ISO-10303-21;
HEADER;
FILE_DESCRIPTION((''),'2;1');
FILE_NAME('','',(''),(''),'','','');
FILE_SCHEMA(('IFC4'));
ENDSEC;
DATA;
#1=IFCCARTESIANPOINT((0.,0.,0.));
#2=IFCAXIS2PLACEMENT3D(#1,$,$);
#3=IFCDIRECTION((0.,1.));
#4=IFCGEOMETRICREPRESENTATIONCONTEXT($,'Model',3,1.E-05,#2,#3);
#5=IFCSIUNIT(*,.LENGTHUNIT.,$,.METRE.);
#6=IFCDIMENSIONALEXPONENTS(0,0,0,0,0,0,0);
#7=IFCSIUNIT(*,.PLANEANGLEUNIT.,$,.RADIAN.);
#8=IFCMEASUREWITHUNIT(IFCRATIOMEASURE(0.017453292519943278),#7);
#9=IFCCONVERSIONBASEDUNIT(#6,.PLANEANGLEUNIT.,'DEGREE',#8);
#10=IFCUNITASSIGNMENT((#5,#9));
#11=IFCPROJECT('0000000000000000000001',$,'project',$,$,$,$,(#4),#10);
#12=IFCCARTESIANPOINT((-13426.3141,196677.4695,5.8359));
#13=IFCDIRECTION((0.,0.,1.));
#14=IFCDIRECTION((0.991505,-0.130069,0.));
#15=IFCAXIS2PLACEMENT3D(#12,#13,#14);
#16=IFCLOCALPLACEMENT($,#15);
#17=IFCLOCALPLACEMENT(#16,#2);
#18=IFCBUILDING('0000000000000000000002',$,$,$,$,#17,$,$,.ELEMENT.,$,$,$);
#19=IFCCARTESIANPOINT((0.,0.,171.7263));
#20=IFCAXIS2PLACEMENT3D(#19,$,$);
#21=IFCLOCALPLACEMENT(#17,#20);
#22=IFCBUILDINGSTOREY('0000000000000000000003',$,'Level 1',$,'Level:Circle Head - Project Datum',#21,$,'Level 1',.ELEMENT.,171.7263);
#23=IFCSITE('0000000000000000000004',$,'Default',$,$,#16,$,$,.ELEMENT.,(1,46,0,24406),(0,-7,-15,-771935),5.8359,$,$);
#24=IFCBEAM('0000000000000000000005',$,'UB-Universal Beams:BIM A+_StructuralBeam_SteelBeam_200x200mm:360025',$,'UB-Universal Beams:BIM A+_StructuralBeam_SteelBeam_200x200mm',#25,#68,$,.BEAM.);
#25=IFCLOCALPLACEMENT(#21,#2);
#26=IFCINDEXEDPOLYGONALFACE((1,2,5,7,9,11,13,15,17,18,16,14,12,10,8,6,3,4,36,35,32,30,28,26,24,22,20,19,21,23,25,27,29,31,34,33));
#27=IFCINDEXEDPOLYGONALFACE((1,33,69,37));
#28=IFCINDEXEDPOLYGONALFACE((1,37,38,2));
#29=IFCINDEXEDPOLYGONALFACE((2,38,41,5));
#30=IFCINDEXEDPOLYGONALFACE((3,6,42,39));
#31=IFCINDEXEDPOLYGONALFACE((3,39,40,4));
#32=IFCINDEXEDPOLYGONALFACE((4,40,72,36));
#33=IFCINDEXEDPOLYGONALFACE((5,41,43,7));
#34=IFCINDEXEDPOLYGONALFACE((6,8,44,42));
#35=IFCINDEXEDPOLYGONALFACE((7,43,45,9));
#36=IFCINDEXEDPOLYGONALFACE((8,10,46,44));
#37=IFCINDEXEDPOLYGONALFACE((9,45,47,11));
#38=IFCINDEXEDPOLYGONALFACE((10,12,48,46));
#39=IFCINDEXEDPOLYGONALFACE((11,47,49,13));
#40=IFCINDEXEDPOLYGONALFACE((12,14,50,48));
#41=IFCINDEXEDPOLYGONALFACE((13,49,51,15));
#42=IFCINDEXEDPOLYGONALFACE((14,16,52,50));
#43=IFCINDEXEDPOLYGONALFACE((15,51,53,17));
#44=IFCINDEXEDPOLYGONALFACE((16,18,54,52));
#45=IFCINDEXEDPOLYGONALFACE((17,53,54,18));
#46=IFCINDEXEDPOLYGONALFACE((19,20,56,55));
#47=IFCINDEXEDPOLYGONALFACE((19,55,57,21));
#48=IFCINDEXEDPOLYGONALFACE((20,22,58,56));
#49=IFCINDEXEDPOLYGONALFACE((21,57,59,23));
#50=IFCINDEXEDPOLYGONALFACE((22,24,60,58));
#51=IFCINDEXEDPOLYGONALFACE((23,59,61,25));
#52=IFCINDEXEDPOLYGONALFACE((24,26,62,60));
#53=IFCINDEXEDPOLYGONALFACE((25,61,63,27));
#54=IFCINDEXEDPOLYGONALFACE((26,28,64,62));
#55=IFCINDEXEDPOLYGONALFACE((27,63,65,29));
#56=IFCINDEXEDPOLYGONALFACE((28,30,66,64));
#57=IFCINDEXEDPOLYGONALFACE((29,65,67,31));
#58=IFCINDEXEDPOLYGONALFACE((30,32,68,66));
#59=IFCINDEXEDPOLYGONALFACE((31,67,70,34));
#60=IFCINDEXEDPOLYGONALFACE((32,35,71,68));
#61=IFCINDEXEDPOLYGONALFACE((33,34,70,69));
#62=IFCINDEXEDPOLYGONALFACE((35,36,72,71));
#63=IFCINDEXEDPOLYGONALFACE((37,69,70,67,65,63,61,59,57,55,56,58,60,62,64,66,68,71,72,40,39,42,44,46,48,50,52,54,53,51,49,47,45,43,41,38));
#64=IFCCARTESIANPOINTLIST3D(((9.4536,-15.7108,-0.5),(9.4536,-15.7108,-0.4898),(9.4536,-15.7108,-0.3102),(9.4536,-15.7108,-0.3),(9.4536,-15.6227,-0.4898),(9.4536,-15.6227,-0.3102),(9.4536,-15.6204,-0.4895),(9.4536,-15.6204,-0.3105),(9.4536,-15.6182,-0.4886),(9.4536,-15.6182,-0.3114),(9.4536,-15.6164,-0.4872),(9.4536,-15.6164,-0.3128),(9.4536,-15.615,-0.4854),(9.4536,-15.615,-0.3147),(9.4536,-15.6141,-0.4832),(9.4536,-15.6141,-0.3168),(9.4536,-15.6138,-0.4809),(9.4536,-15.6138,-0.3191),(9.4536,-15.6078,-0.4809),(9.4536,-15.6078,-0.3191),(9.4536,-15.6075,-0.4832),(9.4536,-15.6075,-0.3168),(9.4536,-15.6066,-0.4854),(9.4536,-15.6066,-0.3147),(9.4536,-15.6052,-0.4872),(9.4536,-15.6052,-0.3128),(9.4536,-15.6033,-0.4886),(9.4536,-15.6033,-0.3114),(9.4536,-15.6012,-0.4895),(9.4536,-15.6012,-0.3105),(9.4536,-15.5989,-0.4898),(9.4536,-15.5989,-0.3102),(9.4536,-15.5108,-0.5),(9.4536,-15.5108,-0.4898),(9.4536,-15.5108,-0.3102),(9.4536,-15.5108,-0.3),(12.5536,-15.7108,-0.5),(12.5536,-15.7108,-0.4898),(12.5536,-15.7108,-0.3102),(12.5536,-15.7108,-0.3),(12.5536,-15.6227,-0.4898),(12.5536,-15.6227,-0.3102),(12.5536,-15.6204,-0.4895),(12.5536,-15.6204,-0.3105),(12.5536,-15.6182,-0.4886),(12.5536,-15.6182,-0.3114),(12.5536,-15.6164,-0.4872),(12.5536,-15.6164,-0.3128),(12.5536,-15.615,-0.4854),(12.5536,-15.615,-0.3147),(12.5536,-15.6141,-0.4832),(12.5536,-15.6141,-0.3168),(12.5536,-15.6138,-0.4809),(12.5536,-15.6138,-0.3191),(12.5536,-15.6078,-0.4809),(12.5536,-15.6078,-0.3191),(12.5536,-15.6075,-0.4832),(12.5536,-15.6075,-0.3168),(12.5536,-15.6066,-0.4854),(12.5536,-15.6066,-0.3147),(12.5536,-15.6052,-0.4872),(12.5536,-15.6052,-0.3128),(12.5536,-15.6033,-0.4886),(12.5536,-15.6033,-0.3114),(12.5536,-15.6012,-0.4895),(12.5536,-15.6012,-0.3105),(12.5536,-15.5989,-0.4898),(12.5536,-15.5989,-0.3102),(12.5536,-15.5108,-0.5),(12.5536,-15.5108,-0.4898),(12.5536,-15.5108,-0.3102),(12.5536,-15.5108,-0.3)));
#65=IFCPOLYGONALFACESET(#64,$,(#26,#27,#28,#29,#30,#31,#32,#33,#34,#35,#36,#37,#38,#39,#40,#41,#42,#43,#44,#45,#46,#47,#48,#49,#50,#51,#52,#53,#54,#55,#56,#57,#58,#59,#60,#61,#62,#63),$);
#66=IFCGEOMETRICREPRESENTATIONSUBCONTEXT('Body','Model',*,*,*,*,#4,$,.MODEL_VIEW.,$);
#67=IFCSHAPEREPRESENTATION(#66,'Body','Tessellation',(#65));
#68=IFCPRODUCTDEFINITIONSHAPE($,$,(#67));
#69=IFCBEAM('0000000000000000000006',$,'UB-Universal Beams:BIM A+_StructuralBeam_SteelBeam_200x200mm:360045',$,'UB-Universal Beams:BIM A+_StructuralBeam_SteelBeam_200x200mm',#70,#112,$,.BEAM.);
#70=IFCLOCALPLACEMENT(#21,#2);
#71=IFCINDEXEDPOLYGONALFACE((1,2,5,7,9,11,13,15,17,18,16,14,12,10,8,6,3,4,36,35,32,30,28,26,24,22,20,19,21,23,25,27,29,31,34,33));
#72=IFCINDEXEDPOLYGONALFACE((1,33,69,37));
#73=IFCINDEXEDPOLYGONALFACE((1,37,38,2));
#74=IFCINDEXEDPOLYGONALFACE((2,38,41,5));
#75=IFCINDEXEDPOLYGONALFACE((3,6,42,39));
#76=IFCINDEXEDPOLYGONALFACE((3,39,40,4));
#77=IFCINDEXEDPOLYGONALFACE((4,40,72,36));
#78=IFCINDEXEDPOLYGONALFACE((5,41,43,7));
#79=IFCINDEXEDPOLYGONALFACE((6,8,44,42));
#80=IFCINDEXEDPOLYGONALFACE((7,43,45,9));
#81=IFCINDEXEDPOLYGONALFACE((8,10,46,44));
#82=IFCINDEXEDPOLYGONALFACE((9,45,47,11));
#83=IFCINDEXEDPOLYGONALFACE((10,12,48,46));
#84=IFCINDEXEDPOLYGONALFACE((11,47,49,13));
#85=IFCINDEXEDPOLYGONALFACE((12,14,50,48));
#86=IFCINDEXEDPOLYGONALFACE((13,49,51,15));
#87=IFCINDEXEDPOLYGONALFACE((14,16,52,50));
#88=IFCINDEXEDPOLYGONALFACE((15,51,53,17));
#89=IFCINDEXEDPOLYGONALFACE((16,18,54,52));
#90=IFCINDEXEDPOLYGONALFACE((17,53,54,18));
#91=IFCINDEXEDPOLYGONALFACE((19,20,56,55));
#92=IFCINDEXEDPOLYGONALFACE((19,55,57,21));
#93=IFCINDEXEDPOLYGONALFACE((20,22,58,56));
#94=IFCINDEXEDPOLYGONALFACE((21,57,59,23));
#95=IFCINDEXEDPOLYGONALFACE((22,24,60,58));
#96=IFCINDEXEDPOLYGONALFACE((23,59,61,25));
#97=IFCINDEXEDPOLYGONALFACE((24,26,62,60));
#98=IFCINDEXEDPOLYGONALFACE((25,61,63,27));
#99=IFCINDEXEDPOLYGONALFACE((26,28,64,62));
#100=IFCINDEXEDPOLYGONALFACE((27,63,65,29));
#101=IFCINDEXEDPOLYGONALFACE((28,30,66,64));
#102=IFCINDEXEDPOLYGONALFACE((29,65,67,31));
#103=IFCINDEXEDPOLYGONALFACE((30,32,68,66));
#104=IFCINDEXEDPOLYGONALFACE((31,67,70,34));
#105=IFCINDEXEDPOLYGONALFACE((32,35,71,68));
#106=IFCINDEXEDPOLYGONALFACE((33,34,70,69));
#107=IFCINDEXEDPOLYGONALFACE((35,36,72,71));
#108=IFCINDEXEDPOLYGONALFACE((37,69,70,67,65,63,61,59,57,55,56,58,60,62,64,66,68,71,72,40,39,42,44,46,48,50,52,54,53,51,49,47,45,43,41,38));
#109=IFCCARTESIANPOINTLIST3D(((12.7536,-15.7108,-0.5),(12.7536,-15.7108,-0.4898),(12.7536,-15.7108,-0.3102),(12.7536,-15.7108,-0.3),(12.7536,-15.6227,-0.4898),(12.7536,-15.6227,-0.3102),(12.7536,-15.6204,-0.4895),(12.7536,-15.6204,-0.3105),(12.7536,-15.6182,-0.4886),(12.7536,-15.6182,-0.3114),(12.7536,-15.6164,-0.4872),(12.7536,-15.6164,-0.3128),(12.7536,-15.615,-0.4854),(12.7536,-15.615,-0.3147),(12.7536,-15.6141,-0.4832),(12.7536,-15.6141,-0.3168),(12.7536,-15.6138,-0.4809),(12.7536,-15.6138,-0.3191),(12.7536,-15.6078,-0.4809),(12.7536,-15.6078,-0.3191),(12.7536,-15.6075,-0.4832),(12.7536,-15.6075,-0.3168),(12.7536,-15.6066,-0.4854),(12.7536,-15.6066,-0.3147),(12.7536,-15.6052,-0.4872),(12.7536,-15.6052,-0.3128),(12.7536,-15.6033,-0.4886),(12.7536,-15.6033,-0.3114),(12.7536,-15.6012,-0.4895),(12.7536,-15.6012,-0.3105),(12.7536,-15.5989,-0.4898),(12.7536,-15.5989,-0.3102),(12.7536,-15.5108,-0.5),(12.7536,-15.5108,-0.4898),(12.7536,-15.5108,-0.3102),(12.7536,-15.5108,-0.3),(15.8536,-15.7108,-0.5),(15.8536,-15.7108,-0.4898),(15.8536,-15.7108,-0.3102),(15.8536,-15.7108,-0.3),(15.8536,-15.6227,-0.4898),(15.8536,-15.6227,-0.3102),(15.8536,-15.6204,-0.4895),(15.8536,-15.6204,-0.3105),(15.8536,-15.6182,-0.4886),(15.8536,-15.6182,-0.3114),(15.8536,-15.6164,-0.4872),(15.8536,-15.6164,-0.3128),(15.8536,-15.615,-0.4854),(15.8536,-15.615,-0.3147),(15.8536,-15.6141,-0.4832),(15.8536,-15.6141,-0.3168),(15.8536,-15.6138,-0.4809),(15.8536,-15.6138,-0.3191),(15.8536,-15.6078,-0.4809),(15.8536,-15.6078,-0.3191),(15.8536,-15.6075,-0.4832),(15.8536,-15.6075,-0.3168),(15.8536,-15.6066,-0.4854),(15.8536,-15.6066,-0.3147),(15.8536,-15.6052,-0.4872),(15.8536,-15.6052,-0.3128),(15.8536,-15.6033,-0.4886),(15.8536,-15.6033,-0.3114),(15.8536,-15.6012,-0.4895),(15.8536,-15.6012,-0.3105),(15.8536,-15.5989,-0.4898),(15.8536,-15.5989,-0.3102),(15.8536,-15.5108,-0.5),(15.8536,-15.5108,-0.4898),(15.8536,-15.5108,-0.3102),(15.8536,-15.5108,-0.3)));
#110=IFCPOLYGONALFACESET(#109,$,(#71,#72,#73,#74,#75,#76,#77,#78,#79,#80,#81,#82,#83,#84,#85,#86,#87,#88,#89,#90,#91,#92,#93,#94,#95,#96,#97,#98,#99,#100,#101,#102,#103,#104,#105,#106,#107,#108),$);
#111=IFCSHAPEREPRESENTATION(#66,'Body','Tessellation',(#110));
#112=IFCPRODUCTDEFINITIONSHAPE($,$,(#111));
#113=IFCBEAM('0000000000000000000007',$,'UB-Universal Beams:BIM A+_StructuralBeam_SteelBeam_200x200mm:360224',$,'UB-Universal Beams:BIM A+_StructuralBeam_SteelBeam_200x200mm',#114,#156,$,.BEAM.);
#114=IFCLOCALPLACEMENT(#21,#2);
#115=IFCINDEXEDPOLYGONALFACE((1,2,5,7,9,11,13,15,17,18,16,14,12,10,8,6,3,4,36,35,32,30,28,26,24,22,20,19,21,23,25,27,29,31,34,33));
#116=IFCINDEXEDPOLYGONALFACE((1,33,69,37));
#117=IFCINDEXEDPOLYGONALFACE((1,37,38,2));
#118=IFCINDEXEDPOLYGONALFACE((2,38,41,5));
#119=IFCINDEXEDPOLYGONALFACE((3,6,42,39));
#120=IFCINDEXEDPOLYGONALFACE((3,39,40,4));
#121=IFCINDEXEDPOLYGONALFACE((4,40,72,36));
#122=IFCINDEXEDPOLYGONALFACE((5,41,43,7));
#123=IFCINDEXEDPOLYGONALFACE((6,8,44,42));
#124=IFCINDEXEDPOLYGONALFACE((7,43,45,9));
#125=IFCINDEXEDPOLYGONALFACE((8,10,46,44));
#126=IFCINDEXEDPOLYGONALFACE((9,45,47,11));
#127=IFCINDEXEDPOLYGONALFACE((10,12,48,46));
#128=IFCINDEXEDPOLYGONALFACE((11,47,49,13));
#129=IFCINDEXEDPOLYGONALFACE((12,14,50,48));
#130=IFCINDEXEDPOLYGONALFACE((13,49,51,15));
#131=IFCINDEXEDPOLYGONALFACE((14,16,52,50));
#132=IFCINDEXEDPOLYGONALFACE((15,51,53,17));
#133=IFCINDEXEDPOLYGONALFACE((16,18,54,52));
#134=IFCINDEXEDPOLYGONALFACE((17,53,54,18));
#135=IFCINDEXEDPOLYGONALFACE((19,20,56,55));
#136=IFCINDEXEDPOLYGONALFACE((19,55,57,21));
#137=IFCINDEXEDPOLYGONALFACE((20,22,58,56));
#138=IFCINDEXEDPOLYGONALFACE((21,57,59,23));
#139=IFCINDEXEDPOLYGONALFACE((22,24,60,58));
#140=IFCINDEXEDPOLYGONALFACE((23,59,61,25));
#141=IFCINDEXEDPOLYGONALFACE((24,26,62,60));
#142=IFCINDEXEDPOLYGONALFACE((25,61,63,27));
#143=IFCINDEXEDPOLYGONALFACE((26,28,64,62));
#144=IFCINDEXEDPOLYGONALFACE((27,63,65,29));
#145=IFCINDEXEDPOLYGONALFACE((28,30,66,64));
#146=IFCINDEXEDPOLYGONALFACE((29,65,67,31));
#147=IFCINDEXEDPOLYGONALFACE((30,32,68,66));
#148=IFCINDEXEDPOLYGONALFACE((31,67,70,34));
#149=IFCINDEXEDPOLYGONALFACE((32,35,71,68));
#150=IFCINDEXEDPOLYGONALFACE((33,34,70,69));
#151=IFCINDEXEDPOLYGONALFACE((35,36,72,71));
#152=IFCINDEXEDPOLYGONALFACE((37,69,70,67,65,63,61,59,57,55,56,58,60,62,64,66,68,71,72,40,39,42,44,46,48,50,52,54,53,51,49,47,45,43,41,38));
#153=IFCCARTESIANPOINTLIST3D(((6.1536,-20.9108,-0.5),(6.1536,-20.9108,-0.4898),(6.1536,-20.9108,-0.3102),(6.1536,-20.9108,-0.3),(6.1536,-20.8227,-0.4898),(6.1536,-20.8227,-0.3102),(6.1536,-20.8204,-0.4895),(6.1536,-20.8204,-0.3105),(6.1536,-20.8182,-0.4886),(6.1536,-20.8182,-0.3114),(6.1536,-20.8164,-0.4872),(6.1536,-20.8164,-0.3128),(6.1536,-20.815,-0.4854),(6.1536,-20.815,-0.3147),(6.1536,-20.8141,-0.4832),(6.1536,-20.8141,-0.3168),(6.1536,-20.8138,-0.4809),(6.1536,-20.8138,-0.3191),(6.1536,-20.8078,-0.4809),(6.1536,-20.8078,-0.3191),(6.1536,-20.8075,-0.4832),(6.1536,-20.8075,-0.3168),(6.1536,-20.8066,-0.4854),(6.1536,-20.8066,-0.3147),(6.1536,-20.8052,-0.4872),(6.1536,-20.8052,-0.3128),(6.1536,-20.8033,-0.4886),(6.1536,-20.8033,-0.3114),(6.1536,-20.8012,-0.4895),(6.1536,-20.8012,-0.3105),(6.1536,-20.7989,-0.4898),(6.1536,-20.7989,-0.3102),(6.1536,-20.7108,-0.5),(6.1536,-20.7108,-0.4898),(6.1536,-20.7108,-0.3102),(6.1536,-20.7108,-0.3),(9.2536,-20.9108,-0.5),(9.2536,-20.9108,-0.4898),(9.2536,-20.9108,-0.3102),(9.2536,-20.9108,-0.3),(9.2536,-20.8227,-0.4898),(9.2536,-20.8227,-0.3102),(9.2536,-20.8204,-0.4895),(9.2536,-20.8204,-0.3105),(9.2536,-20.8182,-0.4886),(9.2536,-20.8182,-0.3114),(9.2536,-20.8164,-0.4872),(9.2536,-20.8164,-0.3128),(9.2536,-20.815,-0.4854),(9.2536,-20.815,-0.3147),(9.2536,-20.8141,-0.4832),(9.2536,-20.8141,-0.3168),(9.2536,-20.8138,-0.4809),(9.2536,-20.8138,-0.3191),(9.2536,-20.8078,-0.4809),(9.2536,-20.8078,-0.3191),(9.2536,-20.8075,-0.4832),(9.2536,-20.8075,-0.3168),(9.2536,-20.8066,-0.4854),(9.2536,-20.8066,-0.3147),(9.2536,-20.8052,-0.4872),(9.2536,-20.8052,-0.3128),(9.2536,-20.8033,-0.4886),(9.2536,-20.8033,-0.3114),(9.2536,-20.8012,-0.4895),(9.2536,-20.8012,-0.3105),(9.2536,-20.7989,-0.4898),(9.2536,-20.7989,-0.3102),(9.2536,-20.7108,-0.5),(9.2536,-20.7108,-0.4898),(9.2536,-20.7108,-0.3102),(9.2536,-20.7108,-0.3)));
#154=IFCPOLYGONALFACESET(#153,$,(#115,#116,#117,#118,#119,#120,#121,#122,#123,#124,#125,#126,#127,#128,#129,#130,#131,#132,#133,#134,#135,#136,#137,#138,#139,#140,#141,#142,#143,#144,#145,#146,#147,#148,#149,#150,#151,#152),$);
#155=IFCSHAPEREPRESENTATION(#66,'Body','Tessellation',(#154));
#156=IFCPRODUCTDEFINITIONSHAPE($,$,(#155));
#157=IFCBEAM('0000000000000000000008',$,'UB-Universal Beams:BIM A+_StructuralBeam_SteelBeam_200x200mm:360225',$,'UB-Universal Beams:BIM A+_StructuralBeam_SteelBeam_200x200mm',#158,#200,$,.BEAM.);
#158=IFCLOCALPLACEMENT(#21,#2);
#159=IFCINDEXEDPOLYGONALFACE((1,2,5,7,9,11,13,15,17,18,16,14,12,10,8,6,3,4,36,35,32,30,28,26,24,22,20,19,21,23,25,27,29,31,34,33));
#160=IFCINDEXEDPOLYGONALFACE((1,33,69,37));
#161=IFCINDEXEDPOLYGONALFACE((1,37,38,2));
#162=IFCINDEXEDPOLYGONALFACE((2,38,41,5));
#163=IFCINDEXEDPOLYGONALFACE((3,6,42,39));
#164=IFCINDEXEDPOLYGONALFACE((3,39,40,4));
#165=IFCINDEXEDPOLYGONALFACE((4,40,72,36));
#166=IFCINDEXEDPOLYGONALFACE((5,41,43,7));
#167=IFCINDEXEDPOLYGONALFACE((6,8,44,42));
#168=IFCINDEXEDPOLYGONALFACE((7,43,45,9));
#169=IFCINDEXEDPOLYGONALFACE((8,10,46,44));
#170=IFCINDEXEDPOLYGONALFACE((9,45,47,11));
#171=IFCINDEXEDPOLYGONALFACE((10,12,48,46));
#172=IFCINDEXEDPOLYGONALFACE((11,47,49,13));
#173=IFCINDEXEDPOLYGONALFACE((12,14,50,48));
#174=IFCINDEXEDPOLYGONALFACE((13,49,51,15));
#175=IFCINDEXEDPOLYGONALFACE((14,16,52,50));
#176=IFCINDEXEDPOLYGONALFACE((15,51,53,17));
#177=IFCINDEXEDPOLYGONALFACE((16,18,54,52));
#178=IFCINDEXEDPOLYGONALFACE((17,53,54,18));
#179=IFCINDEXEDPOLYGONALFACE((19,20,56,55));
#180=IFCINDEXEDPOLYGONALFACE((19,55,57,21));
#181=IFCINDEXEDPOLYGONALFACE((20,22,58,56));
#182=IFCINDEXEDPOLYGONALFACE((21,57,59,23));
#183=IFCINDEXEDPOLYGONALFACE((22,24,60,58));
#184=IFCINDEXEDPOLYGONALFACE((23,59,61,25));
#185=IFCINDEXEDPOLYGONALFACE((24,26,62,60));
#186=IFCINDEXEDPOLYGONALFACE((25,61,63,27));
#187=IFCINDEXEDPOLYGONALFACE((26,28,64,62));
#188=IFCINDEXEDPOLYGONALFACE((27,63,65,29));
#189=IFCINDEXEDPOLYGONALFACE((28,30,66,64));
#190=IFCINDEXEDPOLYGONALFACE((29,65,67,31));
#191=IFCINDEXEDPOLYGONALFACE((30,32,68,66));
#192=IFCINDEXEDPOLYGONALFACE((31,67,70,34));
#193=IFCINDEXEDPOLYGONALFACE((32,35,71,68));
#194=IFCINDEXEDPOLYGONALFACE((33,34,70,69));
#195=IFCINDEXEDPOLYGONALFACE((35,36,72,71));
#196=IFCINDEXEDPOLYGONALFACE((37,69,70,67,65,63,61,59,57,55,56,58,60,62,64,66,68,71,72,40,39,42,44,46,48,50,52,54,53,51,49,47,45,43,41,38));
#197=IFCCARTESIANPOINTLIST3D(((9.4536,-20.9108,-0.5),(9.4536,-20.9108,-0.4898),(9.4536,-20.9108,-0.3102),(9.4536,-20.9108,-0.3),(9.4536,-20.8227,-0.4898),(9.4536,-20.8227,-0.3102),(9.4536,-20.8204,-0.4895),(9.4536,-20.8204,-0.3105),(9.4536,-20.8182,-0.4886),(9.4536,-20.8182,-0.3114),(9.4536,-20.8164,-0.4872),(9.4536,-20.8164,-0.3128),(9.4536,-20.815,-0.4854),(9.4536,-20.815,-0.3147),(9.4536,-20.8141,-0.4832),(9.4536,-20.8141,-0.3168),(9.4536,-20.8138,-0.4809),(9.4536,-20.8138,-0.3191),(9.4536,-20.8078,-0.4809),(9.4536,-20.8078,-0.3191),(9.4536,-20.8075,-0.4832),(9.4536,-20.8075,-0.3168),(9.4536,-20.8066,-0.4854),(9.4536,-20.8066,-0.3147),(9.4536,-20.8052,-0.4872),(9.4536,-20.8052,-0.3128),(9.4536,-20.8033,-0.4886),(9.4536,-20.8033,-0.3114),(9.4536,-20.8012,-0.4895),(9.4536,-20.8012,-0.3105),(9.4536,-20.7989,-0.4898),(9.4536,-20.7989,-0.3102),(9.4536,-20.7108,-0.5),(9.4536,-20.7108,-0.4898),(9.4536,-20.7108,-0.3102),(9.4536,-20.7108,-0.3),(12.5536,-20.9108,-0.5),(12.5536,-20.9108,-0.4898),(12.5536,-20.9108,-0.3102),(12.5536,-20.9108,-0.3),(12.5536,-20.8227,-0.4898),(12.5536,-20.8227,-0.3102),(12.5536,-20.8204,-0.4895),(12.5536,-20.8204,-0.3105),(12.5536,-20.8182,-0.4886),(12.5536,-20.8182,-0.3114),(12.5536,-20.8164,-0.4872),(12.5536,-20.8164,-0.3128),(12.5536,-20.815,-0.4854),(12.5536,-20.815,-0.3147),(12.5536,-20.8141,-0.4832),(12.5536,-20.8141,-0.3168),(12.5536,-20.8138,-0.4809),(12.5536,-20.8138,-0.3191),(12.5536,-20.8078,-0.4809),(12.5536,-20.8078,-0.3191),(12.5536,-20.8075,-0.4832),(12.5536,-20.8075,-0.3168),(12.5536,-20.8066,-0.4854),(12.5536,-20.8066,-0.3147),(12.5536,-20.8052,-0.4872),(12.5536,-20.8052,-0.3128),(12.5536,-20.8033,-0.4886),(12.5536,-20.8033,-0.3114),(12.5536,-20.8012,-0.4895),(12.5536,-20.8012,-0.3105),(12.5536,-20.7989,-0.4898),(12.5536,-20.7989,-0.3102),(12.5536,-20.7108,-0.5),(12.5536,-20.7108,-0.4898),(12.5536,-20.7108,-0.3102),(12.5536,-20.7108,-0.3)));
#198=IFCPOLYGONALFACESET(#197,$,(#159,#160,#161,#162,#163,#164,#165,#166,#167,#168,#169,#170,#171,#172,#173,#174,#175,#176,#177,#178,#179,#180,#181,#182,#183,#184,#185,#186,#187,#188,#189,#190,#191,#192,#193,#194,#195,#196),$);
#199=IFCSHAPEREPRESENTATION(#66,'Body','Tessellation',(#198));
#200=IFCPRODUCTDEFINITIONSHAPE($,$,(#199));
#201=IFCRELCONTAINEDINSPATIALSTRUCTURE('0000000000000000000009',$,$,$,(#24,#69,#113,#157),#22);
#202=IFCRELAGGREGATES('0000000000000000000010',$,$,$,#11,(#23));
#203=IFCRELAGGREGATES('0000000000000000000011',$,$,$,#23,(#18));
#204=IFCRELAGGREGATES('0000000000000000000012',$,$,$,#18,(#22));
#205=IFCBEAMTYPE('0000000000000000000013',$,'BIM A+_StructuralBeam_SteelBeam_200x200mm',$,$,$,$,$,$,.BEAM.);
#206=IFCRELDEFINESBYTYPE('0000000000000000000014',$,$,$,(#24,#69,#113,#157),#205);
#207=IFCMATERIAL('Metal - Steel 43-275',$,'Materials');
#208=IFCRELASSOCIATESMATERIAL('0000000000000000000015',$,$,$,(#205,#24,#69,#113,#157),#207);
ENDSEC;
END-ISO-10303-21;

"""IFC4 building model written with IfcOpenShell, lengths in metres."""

from ifc_helpers import new_model, entity, si_unit, converted_unit, direction, frame, origin, place, context, subcontext, project, spatial, line, arc, indexed_curve, outline, extrude, source, transform, mapped, material, type_object, type_shapes, element, save


model = new_model("IFC4")

# Units and contexts
model_context = context("Model", 3, precision=1e-05, world=origin(), true_north=direction((0.0, 1.0)))
body_context = subcontext(model_context, "Body", "Model", "MODEL_VIEW")
ifc_project = project(units=[si_unit("LENGTHUNIT", "METRE"), converted_unit("PLANEANGLEUNIT", "DEGREE", entity("IfcRatioMeasure", 0.017453292519943278), si_unit("PLANEANGLEUNIT", "RADIAN"), dimensions=[0, 0, 0, 0, 0, 0, 0])], contexts=[model_context])

# Site, building, storey
site_placement = place(None, frame((-13426.3141, 196677.4695, 5.8359), z_axis=(0.0, 0.0, 1.0), x_axis=(0.991505, -0.130069, 0.0)))
site = spatial("IfcSite", under=ifc_project, at=site_placement, Name="Default", CompositionType="ELEMENT", RefLatitude=(1, 46, 0, 24406), RefLongitude=(0, -7, -15, -771935), RefElevation=5.8359)
building_placement = place(site_placement, origin())
building = spatial("IfcBuilding", under=site, at=building_placement, CompositionType="ELEMENT")
storey_placement = place(building_placement, frame((0.0, 0.0, 171.7263)))
storey = spatial("IfcBuildingStorey", under=building, at=storey_placement, Name="Level 1", ObjectType="Level:Circle Head - Project Datum", LongName="Level 1", CompositionType="ELEMENT", Elevation=171.7263)

# Beams
ifc_material_1 = material(Name="Metal - Steel 43-275", Category="Materials")
beam_type_1 = type_object("IfcBeamType", Name="BIM A+_StructuralBeam_SteelBeam_200x200mm", PredefinedType="BEAM", material=ifc_material_1)
shared_shape_1 = source(origin(), body_context, "Body", "SweptSolid", [
    extrude(outline(indexed_curve([(-0.1, -0.1), (-0.0898, -0.1), (-0.0898, -0.0119), (-0.0872, -0.0056), (-0.0809, -0.003), (0.0809, -0.003), (0.0872, -0.0056), (0.0898, -0.0119), (0.0898, -0.1), (0.1, -0.1), (0.1, 0.1), (0.0898, 0.1), (0.0898, 0.0119), (0.0872, 0.0056), (0.0809, 0.003), (-0.0809, 0.003), (-0.0872, 0.0056), (-0.0898, 0.0119), (-0.0898, 0.1), (-0.1, 0.1)], segments=[line(1, 2, 3), arc(3, 4, 5), line(5, 6), arc(6, 7, 8), line(8, 9, 10, 11, 12, 13), arc(13, 14, 15), line(15, 16), arc(16, 17, 18), line(18, 19, 20, 1)], self_intersect=False)), frame((-0.3639, 0.0, 0.0), z_axis=(1.0, 0.0, 0.0), x_axis=(0.0, 0.0, -1.0)), (0.0, 0.0, 1.0), 3.1),
])
type_shapes(beam_type_1, [shared_shape_1])
for number, where, z_axis, x_axis, name in (
    (1, (12.1897, -15.6108, -0.4), (0.0, 0.0, 1.0), (-1.0, 0.0, 0.0), "UB-Universal Beams:BIM A+_StructuralBeam_SteelBeam_200x200mm:360025"),
    (2, (15.4897, -15.6108, -0.4), (0.0, 0.0, 1.0), (-1.0, 0.0, 0.0), "UB-Universal Beams:BIM A+_StructuralBeam_SteelBeam_200x200mm:360045"),
    (3, (8.8897, -20.8108, -0.4), (0.0, 0.0, 1.0), (-1.0, 0.0, 0.0), "UB-Universal Beams:BIM A+_StructuralBeam_SteelBeam_200x200mm:360224"),
    (4, (12.1897, -20.8108, -0.4), (0.0, 0.0, 1.0), (-1.0, 0.0, 0.0), "UB-Universal Beams:BIM A+_StructuralBeam_SteelBeam_200x200mm:360225"),
):
    element("IfcBeam", number, at=place(storey_placement, frame(where, z_axis=z_axis, x_axis=x_axis)), inside=storey, type_object=beam_type_1, material=ifc_material_1, Name=name, ObjectType="UB-Universal Beams:BIM A+_StructuralBeam_SteelBeam_200x200mm", PredefinedType="BEAM", context=body_context, shape_type="MappedRepresentation", body=[
        mapped(shared_shape_1, transform((0.0, 0.0, 0.0), scale=1.0)),
    ])

save(model, "model.ifc")
